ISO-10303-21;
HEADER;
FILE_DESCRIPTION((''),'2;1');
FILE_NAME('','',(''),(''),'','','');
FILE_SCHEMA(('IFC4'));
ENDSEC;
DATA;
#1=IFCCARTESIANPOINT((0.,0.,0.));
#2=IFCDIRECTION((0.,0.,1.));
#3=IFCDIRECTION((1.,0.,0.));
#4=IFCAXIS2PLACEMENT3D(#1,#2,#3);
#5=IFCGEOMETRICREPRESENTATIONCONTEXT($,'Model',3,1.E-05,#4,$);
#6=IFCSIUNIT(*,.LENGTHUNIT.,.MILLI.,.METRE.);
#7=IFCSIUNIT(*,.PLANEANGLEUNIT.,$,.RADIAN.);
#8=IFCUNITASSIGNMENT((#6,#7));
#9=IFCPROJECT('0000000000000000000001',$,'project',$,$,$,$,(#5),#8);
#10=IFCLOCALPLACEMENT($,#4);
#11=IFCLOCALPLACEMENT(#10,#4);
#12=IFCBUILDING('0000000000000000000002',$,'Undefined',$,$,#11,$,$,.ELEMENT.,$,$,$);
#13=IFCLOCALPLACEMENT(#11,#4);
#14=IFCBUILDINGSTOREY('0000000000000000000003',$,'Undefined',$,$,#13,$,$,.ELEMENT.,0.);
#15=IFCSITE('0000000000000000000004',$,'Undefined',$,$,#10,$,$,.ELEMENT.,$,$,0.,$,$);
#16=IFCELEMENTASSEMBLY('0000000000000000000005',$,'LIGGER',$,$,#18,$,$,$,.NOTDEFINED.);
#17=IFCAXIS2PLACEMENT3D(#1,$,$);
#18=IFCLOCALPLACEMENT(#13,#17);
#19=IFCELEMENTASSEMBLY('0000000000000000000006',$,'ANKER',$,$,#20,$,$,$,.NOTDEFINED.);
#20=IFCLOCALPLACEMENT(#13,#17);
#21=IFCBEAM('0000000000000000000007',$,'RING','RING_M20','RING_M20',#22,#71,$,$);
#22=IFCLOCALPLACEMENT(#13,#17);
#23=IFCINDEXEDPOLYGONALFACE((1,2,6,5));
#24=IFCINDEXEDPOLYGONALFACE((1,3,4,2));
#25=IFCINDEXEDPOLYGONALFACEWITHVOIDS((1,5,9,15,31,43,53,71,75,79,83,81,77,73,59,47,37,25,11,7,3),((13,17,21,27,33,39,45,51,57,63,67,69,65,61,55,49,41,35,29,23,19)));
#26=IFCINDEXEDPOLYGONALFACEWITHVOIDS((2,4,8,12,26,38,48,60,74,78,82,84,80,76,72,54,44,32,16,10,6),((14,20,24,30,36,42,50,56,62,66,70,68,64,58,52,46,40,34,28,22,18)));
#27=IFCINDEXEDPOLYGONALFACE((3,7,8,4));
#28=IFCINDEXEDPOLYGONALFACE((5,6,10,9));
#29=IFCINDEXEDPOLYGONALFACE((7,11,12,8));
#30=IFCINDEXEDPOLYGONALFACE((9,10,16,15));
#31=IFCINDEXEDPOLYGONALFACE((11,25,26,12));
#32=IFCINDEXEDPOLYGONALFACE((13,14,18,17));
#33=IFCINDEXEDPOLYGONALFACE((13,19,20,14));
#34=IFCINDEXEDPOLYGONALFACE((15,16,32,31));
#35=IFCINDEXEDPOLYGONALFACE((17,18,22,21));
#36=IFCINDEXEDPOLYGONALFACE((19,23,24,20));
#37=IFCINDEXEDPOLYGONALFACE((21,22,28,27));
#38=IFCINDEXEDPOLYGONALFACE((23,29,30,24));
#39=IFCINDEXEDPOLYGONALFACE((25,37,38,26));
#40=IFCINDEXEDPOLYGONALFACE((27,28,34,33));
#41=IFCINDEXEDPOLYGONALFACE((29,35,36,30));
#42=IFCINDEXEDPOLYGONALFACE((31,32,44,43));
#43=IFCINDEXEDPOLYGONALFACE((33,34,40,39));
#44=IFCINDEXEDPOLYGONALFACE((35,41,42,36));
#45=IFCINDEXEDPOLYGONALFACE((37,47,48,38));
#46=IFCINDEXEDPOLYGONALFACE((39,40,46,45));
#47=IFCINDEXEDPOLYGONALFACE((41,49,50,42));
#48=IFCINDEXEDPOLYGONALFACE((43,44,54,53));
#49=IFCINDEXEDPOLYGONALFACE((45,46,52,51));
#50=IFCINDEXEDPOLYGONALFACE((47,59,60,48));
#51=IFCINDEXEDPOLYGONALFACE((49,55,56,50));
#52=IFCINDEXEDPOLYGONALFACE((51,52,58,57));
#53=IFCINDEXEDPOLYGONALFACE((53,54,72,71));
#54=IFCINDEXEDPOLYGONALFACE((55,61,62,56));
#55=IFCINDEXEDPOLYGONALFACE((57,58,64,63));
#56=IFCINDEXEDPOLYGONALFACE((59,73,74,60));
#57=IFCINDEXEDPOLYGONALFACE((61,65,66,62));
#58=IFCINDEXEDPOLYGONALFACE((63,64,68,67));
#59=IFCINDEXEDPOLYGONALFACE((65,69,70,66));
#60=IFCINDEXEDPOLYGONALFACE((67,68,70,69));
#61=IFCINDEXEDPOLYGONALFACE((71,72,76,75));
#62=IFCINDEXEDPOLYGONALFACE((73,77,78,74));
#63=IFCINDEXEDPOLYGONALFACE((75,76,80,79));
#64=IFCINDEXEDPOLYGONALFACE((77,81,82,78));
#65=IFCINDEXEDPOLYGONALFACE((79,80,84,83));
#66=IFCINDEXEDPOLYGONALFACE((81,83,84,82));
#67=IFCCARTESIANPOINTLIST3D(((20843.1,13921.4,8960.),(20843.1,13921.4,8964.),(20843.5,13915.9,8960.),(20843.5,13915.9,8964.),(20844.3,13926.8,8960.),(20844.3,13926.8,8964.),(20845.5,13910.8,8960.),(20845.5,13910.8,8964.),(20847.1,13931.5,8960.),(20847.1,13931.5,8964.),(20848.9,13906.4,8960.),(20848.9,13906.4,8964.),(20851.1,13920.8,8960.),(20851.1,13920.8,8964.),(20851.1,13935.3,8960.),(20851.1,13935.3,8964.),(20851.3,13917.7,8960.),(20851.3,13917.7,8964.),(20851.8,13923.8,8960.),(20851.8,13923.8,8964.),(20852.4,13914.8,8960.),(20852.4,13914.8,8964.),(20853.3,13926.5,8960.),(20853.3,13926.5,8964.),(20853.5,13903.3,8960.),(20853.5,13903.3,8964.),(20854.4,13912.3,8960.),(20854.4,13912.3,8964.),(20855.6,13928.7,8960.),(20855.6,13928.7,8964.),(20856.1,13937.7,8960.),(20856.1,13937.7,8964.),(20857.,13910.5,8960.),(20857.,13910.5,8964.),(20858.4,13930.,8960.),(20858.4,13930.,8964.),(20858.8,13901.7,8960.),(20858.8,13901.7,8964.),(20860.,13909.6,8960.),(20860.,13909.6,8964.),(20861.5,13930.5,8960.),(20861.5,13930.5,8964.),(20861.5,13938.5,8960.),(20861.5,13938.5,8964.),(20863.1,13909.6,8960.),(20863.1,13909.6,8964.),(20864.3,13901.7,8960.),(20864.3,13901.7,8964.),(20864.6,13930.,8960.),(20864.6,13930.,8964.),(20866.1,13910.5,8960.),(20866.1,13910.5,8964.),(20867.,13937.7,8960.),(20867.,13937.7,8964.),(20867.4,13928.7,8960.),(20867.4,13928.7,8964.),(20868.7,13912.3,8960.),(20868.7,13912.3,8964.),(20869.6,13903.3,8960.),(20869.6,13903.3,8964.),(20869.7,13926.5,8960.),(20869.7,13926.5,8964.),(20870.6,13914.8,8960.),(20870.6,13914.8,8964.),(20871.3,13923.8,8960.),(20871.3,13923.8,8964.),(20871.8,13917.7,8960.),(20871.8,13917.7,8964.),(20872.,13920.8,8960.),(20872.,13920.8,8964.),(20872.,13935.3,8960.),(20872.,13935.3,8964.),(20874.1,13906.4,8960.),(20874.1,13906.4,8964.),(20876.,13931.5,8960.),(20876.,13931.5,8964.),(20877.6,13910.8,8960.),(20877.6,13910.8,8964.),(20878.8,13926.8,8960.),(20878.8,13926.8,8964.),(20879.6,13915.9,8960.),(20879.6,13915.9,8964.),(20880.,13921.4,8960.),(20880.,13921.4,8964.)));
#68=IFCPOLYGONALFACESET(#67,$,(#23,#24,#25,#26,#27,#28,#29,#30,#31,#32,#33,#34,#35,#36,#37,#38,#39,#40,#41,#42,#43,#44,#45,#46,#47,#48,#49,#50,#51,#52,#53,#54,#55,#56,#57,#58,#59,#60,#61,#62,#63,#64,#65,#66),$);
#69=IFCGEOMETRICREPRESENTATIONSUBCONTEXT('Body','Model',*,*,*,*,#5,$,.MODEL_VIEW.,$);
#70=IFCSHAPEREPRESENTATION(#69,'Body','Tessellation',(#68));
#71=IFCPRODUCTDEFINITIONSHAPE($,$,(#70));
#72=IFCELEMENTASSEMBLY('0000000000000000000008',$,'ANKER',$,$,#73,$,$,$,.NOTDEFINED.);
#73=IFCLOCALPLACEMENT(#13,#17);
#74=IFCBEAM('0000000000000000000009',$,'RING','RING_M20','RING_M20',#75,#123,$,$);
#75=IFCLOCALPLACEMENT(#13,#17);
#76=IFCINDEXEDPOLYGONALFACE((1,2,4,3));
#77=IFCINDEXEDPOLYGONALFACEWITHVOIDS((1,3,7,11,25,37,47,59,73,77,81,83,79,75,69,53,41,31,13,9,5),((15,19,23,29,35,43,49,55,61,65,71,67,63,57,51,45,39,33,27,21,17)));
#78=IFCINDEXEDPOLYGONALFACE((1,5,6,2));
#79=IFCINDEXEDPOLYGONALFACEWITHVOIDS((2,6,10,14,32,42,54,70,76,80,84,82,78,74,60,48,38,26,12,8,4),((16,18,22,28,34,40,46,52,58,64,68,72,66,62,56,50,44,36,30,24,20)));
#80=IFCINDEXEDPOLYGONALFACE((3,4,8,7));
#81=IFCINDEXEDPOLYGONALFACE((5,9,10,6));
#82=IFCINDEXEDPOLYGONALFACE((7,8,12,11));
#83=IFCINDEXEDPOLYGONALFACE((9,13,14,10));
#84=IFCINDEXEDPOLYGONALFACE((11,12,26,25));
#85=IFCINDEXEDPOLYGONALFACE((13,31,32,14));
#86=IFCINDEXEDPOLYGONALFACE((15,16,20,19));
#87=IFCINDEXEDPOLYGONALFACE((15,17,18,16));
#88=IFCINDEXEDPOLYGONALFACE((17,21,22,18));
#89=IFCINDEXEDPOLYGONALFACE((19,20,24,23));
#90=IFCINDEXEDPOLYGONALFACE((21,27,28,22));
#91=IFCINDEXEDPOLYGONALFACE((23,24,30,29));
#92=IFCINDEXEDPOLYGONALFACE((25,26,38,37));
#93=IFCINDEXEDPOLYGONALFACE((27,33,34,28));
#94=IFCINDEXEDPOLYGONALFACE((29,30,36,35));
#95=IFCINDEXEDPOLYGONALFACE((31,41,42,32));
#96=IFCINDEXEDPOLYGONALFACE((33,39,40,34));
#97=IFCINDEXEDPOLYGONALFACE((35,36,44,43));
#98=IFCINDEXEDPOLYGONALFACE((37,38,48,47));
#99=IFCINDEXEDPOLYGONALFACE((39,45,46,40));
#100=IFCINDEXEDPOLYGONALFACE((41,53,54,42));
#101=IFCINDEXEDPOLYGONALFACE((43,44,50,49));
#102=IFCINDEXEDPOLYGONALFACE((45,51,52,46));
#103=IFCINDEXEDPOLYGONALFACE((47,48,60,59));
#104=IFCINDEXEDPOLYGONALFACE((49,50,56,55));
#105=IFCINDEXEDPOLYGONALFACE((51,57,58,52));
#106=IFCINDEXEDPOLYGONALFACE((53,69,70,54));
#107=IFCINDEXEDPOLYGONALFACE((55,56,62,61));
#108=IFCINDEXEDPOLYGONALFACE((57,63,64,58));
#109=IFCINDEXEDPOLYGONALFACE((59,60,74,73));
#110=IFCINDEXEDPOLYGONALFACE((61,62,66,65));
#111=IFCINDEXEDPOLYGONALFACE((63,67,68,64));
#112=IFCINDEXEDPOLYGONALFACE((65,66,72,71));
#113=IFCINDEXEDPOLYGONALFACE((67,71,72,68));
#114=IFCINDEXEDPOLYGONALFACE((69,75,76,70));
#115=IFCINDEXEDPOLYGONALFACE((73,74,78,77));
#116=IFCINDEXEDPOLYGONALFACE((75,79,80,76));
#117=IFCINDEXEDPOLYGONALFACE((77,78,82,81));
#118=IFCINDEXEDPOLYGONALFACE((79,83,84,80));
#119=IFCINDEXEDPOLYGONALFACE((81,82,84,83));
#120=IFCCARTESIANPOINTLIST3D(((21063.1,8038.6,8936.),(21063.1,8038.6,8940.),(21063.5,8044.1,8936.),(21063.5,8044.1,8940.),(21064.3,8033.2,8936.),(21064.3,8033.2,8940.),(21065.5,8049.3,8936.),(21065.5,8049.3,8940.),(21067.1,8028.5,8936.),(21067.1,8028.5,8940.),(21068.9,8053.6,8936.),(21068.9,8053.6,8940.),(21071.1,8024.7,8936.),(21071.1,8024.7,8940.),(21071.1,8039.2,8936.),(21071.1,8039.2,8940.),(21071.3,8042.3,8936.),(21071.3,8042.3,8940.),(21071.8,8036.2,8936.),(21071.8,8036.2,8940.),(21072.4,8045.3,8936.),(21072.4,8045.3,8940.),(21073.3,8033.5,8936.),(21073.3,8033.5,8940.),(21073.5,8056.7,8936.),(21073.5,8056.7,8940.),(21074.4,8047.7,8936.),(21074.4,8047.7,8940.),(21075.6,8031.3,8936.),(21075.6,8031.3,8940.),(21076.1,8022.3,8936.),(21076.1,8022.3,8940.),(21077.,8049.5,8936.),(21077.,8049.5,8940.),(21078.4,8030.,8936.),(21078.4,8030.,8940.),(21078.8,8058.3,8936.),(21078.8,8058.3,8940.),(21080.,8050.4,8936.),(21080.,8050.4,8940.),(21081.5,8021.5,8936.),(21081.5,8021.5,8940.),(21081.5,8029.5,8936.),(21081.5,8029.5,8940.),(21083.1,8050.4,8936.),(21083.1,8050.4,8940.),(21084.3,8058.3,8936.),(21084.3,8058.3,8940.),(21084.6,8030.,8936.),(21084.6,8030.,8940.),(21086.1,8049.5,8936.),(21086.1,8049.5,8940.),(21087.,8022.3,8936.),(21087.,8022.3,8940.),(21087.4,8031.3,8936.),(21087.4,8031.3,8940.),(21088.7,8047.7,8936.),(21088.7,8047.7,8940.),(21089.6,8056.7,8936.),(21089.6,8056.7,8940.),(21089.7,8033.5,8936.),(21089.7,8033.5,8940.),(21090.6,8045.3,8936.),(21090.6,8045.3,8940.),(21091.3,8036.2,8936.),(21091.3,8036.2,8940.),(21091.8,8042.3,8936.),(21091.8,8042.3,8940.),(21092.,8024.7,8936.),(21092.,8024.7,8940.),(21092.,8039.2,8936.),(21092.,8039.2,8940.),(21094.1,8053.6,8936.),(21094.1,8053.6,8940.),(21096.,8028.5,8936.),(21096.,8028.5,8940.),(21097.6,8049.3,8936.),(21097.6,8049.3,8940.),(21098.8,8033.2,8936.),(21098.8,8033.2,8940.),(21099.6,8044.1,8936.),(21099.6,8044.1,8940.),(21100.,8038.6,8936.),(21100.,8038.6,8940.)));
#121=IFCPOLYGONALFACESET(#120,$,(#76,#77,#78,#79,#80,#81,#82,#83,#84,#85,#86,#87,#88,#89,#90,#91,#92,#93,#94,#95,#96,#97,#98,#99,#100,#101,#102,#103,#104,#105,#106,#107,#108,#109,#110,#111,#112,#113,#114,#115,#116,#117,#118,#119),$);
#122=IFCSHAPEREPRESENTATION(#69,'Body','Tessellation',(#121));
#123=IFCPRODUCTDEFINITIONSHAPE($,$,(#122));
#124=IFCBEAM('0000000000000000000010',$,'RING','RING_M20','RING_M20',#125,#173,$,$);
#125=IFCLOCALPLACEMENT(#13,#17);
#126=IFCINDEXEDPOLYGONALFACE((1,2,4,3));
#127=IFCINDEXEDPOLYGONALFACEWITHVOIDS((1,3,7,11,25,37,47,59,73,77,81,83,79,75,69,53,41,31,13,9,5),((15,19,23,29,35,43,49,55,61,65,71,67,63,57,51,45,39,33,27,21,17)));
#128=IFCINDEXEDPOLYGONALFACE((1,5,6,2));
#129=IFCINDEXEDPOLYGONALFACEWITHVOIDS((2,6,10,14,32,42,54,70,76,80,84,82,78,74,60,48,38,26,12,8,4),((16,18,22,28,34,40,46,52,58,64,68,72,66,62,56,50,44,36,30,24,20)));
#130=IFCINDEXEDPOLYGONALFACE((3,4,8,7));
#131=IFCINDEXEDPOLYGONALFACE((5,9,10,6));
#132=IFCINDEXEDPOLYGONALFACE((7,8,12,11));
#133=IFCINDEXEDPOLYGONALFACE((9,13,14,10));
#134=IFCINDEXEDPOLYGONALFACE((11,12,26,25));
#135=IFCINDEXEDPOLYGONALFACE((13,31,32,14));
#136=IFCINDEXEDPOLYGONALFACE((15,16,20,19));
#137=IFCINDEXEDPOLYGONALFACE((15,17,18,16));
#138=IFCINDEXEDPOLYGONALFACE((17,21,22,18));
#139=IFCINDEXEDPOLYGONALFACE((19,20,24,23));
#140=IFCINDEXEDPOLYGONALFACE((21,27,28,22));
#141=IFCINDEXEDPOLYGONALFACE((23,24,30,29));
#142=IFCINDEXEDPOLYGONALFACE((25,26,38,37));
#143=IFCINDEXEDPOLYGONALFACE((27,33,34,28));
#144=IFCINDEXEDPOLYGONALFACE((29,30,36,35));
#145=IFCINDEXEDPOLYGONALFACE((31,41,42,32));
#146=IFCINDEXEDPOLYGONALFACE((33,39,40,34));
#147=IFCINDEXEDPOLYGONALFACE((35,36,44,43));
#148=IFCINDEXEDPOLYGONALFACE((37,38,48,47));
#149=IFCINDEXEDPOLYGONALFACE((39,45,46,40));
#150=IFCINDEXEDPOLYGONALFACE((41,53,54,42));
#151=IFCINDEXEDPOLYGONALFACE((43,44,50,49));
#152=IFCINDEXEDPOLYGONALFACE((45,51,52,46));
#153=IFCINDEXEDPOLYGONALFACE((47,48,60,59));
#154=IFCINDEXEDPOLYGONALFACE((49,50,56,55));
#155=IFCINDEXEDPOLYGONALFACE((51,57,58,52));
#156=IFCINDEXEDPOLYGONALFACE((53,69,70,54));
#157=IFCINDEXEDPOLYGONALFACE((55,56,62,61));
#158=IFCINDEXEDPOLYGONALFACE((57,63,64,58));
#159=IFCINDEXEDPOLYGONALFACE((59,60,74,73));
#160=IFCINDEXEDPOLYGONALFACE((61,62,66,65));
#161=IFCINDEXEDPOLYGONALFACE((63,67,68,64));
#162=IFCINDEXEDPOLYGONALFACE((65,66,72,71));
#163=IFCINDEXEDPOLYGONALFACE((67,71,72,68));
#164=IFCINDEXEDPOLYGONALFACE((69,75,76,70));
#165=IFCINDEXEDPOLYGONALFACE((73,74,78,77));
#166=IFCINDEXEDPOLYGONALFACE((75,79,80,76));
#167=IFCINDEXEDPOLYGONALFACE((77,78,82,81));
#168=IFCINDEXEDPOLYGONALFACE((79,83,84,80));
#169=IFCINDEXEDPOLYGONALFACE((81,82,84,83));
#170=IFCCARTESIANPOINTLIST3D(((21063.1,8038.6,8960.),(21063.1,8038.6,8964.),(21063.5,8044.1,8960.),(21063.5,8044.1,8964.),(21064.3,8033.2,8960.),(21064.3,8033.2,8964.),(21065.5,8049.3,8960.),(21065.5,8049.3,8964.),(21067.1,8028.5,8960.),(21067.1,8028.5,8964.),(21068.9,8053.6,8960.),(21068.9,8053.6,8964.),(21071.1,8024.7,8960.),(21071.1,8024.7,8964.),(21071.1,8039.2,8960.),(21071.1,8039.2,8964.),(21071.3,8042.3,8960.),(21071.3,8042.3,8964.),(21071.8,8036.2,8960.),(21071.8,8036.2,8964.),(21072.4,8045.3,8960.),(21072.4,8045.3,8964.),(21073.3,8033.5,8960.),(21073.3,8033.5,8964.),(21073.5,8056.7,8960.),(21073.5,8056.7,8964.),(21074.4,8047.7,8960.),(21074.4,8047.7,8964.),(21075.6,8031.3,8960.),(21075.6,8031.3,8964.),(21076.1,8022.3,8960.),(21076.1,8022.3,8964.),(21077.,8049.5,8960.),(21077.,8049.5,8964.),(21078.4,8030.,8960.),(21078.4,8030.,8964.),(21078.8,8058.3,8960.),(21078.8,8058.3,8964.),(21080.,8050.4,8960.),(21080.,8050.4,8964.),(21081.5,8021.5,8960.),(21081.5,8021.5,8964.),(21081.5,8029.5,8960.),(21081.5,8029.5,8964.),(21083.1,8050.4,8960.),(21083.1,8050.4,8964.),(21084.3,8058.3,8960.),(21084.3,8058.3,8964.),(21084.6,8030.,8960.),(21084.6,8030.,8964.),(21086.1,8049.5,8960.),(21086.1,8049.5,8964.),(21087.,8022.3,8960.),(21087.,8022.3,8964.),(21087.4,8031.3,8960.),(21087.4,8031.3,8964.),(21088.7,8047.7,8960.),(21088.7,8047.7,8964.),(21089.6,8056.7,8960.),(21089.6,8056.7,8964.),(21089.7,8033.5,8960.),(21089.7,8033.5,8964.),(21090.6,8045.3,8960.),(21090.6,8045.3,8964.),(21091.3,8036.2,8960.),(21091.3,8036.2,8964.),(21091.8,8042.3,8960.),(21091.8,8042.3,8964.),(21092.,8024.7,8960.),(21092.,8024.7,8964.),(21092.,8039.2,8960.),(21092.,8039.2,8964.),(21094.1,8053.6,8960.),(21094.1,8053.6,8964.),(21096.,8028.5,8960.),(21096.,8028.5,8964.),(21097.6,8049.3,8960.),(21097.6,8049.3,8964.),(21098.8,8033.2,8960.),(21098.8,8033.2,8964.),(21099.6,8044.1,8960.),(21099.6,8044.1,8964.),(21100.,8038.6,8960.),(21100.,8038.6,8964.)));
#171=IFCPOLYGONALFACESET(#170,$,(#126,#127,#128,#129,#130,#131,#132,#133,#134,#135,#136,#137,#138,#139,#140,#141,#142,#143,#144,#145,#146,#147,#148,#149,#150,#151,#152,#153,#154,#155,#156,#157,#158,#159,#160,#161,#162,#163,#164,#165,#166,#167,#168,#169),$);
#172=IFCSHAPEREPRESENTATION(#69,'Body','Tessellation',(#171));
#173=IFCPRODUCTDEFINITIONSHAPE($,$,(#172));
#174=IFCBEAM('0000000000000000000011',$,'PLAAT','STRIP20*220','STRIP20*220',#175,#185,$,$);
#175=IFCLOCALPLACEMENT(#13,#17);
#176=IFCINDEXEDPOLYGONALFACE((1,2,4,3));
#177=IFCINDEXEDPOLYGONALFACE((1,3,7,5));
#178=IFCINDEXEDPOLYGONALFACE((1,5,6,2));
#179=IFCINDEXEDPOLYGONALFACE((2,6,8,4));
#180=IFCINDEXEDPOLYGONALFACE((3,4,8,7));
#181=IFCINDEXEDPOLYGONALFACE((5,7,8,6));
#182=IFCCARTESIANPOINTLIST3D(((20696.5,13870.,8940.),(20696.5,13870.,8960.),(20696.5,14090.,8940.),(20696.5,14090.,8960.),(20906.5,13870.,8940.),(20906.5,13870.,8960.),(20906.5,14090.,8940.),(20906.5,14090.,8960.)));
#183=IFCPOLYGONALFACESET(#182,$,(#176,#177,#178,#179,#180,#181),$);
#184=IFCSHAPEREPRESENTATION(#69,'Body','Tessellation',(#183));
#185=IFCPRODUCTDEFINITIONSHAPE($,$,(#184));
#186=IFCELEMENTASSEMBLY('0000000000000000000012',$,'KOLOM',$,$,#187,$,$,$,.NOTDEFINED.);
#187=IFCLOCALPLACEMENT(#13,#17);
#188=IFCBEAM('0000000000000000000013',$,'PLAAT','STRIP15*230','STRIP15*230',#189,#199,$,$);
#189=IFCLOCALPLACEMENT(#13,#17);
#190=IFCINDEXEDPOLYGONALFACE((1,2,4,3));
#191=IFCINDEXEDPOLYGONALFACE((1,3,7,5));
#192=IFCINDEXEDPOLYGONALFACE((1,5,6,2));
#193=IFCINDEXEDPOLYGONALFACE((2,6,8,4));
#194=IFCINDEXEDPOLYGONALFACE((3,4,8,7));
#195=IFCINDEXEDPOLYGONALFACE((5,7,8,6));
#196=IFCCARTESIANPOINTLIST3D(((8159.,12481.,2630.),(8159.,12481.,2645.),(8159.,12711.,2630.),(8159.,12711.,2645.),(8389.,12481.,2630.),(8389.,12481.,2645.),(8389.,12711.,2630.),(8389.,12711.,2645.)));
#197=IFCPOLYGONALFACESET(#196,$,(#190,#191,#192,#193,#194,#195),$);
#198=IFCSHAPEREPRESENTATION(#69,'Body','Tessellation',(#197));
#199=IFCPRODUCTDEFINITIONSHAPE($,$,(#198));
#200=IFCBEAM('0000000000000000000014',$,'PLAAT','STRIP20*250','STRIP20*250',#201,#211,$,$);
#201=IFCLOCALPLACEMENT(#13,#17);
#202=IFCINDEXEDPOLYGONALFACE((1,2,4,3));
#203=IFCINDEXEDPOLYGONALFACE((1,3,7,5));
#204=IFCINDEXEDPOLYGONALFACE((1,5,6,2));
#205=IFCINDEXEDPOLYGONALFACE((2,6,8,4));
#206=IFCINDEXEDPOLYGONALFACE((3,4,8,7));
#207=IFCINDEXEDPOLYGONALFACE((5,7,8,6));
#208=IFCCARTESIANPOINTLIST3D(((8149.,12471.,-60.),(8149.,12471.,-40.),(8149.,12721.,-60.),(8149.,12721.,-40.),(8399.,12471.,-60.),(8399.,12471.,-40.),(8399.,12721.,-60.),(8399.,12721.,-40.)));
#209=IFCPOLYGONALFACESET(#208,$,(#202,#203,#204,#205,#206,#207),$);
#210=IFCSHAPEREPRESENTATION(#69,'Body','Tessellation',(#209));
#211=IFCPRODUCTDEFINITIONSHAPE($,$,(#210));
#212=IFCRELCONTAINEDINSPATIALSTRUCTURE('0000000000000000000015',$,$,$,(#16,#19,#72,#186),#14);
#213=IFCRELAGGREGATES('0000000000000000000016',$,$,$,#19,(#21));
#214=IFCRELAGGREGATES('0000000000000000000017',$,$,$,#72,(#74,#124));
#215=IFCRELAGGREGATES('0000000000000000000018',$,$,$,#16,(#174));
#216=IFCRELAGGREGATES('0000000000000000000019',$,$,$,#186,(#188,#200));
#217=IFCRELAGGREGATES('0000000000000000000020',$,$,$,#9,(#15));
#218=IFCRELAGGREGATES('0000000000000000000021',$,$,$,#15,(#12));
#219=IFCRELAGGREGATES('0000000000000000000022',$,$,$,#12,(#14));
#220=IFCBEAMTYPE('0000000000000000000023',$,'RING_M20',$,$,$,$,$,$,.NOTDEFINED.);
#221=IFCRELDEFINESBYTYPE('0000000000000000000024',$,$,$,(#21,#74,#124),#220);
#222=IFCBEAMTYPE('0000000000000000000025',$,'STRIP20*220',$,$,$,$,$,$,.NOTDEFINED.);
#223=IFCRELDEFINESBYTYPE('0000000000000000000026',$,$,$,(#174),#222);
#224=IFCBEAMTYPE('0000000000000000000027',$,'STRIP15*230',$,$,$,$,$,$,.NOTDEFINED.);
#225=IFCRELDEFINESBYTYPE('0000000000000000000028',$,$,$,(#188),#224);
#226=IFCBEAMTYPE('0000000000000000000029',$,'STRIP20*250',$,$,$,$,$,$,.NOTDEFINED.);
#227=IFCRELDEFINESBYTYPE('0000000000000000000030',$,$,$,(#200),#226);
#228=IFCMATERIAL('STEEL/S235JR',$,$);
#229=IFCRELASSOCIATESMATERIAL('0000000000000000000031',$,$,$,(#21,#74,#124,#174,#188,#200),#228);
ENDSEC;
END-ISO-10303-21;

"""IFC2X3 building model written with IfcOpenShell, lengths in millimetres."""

from ifc_helpers import new_model, si_unit, frame, origin_with_axes, origin_2d_with_axis, place, context, subcontext, project, spatial, rectangle, hollow_circle, extrude, material, type_object, element, aggregate, save


model = new_model("IFC2X3")

# Units and contexts
model_context = context("Model", 3, precision=1e-05, world=origin_with_axes())
body_context = subcontext(model_context, "Body", "Model", "MODEL_VIEW")
ifc_project = project(units=[si_unit("LENGTHUNIT", "METRE", prefix="MILLI"), si_unit("PLANEANGLEUNIT", "RADIAN")], contexts=[model_context])

# Site, building, storey
site_placement = place(None, origin_with_axes())
site = spatial("IfcSite", under=ifc_project, at=site_placement, Name="Undefined", CompositionType="ELEMENT", RefElevation=0.0)
building_placement = place(site_placement, origin_with_axes())
building = spatial("IfcBuilding", under=site, at=building_placement, Name="Undefined", CompositionType="ELEMENT")
storey_placement = place(building_placement, origin_with_axes())
storey = spatial("IfcBuildingStorey", under=building, at=storey_placement, Name="Undefined", CompositionType="ELEMENT", Elevation=0.0)

# Shared definitions
ifc_material = material(Name="STEEL/S235JR")

# Element assembly
assembly_1_placement = place(storey_placement, frame((19599.0, 13980.0, 11793.5), z_axis=(0.906308, 0.0, 0.422618), x_axis=(0.422618, 0.0, -0.906308)))
assembly_1 = element("IfcElementAssembly", 1, at=assembly_1_placement, inside=storey, Name="LIGGER", PredefinedType="NOTDEFINED")

# Element assemblies, beams
beam_type_1 = type_object("IfcBeamType", Name="RING_M20", PredefinedType="NOTDEFINED")
assembly_2_placement = place(storey_placement, frame((20861.5, 13920.0, 9010.0), z_axis=(0.0, 1.0, 0.0), x_axis=(0.0, 0.0, -1.0)))
assembly_2 = element("IfcElementAssembly", 2, at=assembly_2_placement, inside=storey, Name="ANKER", PredefinedType="NOTDEFINED")
beam_1_placement = place(storey_placement, frame((20861.5, 13920.0, 8964.0), z_axis=(-1.0, 0.0, 0.0), x_axis=(0.0, 0.0, -1.0)))
beam_1 = element("IfcBeam", 3, at=beam_1_placement, type_object=beam_type_1, material=ifc_material, Name="RING", Description="RING_M20", ObjectType="RING_M20", context=body_context, shape_type="SweptSolid", body=[
    extrude(hollow_circle(Radius=18.5, WallThickness=8.0, at=origin_2d_with_axis()), frame((4.0, 0.0, 0.0), z_axis=(-1.0, 0.0, 0.0), x_axis=(0.0, -1.0, 0.0)), (0.0, 0.0, 1.0), 4.0),
])
aggregate(assembly_2, [beam_1])
assembly_3_placement = place(storey_placement, frame((21081.5, 8040.0, 9010.0), z_axis=(0.0, 1.0, 0.0), x_axis=(0.0, 0.0, -1.0)))
assembly_3 = element("IfcElementAssembly", 4, at=assembly_3_placement, inside=storey, Name="ANKER", PredefinedType="NOTDEFINED")
beam_2_placement = place(storey_placement, frame((21081.5, 8040.0, 8940.0), z_axis=(1.0, 0.0, 0.0), x_axis=(0.0, 0.0, -1.0)))
beam_2 = element("IfcBeam", 5, at=beam_2_placement, type_object=beam_type_1, material=ifc_material, Name="RING", Description="RING_M20", ObjectType="RING_M20", context=body_context, shape_type="SweptSolid", body=[
    extrude(hollow_circle(Radius=18.5, WallThickness=8.0, at=origin_2d_with_axis()), frame((4.0, 0.0, 0.0), z_axis=(-1.0, 0.0, 0.0), x_axis=(0.0, -1.0, 0.0)), (0.0, 0.0, 1.0), 4.0),
])
beam_3_placement = place(storey_placement, frame((21081.5, 8040.0, 8964.0), z_axis=(1.0, 0.0, 0.0), x_axis=(0.0, 0.0, -1.0)))
beam_3 = element("IfcBeam", 6, at=beam_3_placement, type_object=beam_type_1, material=ifc_material, Name="RING", Description="RING_M20", ObjectType="RING_M20", context=body_context, shape_type="SweptSolid", body=[
    extrude(hollow_circle(Radius=18.5, WallThickness=8.0, at=origin_2d_with_axis()), frame((4.0, 0.0, 0.0), z_axis=(-1.0, 0.0, 0.0), x_axis=(0.0, -1.0, 0.0)), (0.0, 0.0, 1.0), 4.0),
])
aggregate(assembly_3, [beam_2, beam_3])

# Beam
beam_type_2 = type_object("IfcBeamType", Name="STRIP20*220", PredefinedType="NOTDEFINED")
beam_4_placement = place(storey_placement, frame((20696.5, 13980.0, 8950.0), z_axis=(0.0, 1.0, 0.0), x_axis=(1.0, 0.0, 0.0)))
beam_4 = element("IfcBeam", 7, at=beam_4_placement, type_object=beam_type_2, material=ifc_material, Name="PLAAT", Description="STRIP20*220", ObjectType="STRIP20*220", context=body_context, shape_type="SweptSolid", body=[
    extrude(rectangle(XDim=20.0, YDim=220.0, at=origin_2d_with_axis()), frame((210.0, 0.0, 0.0), z_axis=(-1.0, 0.0, 0.0), x_axis=(0.0, -1.0, 0.0)), (0.0, 0.0, 1.0), 210.0),
])
aggregate(assembly_1, [beam_4])

# Element assembly, beams
assembly_4_placement = place(storey_placement, frame((8274.0, 12596.0, -60.0), z_axis=(-1.0, 0.0, 0.0), x_axis=(0.0, 0.0, 1.0)))
assembly_4 = element("IfcElementAssembly", 8, at=assembly_4_placement, inside=storey, Name="KOLOM", PredefinedType="NOTDEFINED")
beam_type_3 = type_object("IfcBeamType", Name="STRIP15*230", PredefinedType="NOTDEFINED")
beam_5_placement = place(storey_placement, frame((8389.0, 12596.0, 2637.5), z_axis=(0.0, 1.0, 0.0), x_axis=(-1.0, 0.0, 0.0)))
beam_5 = element("IfcBeam", 9, at=beam_5_placement, type_object=beam_type_3, material=ifc_material, Name="PLAAT", Description="STRIP15*230", ObjectType="STRIP15*230", context=body_context, shape_type="SweptSolid", body=[
    extrude(rectangle(XDim=15.0, YDim=230.0, at=origin_2d_with_axis()), frame((230.0, 0.0, 0.0), z_axis=(-1.0, 0.0, 0.0), x_axis=(0.0, -1.0, 0.0)), (0.0, 0.0, 1.0), 230.0),
])
beam_type_4 = type_object("IfcBeamType", Name="STRIP20*250", PredefinedType="NOTDEFINED")
beam_6_placement = place(storey_placement, frame((8399.0, 12596.0, -50.0), z_axis=(0.0, -1.0, 0.0), x_axis=(-1.0, 0.0, 0.0)))
beam_6 = element("IfcBeam", 10, at=beam_6_placement, type_object=beam_type_4, material=ifc_material, Name="PLAAT", Description="STRIP20*250", ObjectType="STRIP20*250", context=body_context, shape_type="SweptSolid", body=[
    extrude(rectangle(XDim=20.0, YDim=250.0, at=origin_2d_with_axis()), frame((250.0, 0.0, 0.0), z_axis=(-1.0, 0.0, 0.0), x_axis=(0.0, -1.0, 0.0)), (0.0, 0.0, 1.0), 250.0),
])
aggregate(assembly_4, [beam_5, beam_6])

save(model, "model.ifc")
